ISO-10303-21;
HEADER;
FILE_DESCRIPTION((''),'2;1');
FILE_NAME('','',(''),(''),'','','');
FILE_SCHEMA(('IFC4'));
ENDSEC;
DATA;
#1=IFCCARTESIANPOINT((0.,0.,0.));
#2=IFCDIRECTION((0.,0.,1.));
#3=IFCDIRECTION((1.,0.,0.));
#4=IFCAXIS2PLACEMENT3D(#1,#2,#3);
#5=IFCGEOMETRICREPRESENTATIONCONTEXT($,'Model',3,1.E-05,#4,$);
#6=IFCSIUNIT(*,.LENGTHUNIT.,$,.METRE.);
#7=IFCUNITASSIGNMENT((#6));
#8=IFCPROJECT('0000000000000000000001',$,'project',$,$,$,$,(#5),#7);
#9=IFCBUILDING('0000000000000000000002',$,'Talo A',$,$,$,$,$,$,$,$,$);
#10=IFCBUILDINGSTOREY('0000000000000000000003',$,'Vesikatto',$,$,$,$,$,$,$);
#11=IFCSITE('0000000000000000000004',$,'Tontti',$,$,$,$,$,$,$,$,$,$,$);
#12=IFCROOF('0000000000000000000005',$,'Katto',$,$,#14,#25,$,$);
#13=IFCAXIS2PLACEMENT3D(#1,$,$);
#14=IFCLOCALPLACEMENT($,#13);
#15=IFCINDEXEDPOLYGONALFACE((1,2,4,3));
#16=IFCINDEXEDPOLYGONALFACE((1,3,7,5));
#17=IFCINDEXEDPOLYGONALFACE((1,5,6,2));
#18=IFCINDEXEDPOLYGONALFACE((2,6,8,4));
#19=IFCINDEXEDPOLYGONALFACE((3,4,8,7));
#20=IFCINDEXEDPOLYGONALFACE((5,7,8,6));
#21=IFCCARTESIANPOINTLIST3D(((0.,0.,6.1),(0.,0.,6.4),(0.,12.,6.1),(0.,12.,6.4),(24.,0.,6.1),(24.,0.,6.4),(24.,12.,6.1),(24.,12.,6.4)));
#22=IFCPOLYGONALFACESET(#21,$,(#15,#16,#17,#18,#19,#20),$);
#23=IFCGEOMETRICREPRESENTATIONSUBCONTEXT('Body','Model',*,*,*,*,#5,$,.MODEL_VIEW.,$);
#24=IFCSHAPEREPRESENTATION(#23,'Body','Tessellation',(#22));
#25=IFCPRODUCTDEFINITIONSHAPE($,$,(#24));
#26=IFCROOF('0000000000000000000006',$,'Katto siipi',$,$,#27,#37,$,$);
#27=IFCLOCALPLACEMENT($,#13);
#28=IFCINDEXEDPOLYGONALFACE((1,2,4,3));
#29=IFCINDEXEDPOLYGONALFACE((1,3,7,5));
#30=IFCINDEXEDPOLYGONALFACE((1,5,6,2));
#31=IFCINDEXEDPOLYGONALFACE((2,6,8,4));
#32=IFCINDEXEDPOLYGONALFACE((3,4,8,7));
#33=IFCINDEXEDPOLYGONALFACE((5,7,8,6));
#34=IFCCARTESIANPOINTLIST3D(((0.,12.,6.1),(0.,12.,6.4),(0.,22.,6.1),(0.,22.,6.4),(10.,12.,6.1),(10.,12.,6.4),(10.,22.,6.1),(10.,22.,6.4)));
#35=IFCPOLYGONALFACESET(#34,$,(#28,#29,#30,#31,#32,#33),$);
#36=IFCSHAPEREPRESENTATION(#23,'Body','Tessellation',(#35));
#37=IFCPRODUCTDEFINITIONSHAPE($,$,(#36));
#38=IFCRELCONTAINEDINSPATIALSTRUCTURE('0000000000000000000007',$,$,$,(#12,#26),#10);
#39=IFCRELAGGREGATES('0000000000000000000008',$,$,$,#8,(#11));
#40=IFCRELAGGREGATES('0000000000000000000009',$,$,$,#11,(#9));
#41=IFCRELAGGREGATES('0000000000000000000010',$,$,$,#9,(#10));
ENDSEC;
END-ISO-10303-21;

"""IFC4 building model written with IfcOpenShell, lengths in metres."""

from ifc_helpers import new_model, si_unit, frame, origin_with_axes, place, context, subcontext, project, spatial, indexed_curve, outline, extrude, element, save


model = new_model("IFC4")

# Units and contexts
model_context = context("Model", 3, precision=1e-05, world=origin_with_axes())
body_context = subcontext(model_context, "Body", "Model", "MODEL_VIEW")
ifc_project = project(units=[si_unit("LENGTHUNIT", "METRE")], contexts=[model_context])

# Site, building, storey
site = spatial("IfcSite", under=ifc_project, Name="Tontti")
building = spatial("IfcBuilding", under=site, Name="Talo A")
storey = spatial("IfcBuildingStorey", under=building, Name="Vesikatto")

# Roofs
roof_1_placement = place(None, frame((0.0, 0.0, 6.1), z_axis=(0.0, 0.0, 1.0), x_axis=(1.0, 0.0, 0.0)))
element("IfcRoof", 1, at=roof_1_placement, inside=storey, Name="Katto", context=body_context, shape_type="SweptSolid", body=[
    extrude(outline(indexed_curve([(0.0, 0.0), (0.0, 12.0), (24.0, 12.0), (24.0, 0.0), (0.0, 0.0)], self_intersect=False)), origin_with_axes(), (0.0, 0.0, 1.0), 0.3),
])
roof_2_placement = place(None, frame((0.0, 12.0, 6.1), z_axis=(0.0, 0.0, 1.0), x_axis=(1.0, 0.0, 0.0)))
element("IfcRoof", 2, at=roof_2_placement, inside=storey, Name="Katto siipi", context=body_context, shape_type="SweptSolid", body=[
    extrude(outline(indexed_curve([(0.0, 0.0), (0.0, 10.0), (10.0, 10.0), (10.0, 0.0), (0.0, 0.0)], self_intersect=False)), origin_with_axes(), (0.0, 0.0, 1.0), 0.3),
])

save(model, "model.ifc")
